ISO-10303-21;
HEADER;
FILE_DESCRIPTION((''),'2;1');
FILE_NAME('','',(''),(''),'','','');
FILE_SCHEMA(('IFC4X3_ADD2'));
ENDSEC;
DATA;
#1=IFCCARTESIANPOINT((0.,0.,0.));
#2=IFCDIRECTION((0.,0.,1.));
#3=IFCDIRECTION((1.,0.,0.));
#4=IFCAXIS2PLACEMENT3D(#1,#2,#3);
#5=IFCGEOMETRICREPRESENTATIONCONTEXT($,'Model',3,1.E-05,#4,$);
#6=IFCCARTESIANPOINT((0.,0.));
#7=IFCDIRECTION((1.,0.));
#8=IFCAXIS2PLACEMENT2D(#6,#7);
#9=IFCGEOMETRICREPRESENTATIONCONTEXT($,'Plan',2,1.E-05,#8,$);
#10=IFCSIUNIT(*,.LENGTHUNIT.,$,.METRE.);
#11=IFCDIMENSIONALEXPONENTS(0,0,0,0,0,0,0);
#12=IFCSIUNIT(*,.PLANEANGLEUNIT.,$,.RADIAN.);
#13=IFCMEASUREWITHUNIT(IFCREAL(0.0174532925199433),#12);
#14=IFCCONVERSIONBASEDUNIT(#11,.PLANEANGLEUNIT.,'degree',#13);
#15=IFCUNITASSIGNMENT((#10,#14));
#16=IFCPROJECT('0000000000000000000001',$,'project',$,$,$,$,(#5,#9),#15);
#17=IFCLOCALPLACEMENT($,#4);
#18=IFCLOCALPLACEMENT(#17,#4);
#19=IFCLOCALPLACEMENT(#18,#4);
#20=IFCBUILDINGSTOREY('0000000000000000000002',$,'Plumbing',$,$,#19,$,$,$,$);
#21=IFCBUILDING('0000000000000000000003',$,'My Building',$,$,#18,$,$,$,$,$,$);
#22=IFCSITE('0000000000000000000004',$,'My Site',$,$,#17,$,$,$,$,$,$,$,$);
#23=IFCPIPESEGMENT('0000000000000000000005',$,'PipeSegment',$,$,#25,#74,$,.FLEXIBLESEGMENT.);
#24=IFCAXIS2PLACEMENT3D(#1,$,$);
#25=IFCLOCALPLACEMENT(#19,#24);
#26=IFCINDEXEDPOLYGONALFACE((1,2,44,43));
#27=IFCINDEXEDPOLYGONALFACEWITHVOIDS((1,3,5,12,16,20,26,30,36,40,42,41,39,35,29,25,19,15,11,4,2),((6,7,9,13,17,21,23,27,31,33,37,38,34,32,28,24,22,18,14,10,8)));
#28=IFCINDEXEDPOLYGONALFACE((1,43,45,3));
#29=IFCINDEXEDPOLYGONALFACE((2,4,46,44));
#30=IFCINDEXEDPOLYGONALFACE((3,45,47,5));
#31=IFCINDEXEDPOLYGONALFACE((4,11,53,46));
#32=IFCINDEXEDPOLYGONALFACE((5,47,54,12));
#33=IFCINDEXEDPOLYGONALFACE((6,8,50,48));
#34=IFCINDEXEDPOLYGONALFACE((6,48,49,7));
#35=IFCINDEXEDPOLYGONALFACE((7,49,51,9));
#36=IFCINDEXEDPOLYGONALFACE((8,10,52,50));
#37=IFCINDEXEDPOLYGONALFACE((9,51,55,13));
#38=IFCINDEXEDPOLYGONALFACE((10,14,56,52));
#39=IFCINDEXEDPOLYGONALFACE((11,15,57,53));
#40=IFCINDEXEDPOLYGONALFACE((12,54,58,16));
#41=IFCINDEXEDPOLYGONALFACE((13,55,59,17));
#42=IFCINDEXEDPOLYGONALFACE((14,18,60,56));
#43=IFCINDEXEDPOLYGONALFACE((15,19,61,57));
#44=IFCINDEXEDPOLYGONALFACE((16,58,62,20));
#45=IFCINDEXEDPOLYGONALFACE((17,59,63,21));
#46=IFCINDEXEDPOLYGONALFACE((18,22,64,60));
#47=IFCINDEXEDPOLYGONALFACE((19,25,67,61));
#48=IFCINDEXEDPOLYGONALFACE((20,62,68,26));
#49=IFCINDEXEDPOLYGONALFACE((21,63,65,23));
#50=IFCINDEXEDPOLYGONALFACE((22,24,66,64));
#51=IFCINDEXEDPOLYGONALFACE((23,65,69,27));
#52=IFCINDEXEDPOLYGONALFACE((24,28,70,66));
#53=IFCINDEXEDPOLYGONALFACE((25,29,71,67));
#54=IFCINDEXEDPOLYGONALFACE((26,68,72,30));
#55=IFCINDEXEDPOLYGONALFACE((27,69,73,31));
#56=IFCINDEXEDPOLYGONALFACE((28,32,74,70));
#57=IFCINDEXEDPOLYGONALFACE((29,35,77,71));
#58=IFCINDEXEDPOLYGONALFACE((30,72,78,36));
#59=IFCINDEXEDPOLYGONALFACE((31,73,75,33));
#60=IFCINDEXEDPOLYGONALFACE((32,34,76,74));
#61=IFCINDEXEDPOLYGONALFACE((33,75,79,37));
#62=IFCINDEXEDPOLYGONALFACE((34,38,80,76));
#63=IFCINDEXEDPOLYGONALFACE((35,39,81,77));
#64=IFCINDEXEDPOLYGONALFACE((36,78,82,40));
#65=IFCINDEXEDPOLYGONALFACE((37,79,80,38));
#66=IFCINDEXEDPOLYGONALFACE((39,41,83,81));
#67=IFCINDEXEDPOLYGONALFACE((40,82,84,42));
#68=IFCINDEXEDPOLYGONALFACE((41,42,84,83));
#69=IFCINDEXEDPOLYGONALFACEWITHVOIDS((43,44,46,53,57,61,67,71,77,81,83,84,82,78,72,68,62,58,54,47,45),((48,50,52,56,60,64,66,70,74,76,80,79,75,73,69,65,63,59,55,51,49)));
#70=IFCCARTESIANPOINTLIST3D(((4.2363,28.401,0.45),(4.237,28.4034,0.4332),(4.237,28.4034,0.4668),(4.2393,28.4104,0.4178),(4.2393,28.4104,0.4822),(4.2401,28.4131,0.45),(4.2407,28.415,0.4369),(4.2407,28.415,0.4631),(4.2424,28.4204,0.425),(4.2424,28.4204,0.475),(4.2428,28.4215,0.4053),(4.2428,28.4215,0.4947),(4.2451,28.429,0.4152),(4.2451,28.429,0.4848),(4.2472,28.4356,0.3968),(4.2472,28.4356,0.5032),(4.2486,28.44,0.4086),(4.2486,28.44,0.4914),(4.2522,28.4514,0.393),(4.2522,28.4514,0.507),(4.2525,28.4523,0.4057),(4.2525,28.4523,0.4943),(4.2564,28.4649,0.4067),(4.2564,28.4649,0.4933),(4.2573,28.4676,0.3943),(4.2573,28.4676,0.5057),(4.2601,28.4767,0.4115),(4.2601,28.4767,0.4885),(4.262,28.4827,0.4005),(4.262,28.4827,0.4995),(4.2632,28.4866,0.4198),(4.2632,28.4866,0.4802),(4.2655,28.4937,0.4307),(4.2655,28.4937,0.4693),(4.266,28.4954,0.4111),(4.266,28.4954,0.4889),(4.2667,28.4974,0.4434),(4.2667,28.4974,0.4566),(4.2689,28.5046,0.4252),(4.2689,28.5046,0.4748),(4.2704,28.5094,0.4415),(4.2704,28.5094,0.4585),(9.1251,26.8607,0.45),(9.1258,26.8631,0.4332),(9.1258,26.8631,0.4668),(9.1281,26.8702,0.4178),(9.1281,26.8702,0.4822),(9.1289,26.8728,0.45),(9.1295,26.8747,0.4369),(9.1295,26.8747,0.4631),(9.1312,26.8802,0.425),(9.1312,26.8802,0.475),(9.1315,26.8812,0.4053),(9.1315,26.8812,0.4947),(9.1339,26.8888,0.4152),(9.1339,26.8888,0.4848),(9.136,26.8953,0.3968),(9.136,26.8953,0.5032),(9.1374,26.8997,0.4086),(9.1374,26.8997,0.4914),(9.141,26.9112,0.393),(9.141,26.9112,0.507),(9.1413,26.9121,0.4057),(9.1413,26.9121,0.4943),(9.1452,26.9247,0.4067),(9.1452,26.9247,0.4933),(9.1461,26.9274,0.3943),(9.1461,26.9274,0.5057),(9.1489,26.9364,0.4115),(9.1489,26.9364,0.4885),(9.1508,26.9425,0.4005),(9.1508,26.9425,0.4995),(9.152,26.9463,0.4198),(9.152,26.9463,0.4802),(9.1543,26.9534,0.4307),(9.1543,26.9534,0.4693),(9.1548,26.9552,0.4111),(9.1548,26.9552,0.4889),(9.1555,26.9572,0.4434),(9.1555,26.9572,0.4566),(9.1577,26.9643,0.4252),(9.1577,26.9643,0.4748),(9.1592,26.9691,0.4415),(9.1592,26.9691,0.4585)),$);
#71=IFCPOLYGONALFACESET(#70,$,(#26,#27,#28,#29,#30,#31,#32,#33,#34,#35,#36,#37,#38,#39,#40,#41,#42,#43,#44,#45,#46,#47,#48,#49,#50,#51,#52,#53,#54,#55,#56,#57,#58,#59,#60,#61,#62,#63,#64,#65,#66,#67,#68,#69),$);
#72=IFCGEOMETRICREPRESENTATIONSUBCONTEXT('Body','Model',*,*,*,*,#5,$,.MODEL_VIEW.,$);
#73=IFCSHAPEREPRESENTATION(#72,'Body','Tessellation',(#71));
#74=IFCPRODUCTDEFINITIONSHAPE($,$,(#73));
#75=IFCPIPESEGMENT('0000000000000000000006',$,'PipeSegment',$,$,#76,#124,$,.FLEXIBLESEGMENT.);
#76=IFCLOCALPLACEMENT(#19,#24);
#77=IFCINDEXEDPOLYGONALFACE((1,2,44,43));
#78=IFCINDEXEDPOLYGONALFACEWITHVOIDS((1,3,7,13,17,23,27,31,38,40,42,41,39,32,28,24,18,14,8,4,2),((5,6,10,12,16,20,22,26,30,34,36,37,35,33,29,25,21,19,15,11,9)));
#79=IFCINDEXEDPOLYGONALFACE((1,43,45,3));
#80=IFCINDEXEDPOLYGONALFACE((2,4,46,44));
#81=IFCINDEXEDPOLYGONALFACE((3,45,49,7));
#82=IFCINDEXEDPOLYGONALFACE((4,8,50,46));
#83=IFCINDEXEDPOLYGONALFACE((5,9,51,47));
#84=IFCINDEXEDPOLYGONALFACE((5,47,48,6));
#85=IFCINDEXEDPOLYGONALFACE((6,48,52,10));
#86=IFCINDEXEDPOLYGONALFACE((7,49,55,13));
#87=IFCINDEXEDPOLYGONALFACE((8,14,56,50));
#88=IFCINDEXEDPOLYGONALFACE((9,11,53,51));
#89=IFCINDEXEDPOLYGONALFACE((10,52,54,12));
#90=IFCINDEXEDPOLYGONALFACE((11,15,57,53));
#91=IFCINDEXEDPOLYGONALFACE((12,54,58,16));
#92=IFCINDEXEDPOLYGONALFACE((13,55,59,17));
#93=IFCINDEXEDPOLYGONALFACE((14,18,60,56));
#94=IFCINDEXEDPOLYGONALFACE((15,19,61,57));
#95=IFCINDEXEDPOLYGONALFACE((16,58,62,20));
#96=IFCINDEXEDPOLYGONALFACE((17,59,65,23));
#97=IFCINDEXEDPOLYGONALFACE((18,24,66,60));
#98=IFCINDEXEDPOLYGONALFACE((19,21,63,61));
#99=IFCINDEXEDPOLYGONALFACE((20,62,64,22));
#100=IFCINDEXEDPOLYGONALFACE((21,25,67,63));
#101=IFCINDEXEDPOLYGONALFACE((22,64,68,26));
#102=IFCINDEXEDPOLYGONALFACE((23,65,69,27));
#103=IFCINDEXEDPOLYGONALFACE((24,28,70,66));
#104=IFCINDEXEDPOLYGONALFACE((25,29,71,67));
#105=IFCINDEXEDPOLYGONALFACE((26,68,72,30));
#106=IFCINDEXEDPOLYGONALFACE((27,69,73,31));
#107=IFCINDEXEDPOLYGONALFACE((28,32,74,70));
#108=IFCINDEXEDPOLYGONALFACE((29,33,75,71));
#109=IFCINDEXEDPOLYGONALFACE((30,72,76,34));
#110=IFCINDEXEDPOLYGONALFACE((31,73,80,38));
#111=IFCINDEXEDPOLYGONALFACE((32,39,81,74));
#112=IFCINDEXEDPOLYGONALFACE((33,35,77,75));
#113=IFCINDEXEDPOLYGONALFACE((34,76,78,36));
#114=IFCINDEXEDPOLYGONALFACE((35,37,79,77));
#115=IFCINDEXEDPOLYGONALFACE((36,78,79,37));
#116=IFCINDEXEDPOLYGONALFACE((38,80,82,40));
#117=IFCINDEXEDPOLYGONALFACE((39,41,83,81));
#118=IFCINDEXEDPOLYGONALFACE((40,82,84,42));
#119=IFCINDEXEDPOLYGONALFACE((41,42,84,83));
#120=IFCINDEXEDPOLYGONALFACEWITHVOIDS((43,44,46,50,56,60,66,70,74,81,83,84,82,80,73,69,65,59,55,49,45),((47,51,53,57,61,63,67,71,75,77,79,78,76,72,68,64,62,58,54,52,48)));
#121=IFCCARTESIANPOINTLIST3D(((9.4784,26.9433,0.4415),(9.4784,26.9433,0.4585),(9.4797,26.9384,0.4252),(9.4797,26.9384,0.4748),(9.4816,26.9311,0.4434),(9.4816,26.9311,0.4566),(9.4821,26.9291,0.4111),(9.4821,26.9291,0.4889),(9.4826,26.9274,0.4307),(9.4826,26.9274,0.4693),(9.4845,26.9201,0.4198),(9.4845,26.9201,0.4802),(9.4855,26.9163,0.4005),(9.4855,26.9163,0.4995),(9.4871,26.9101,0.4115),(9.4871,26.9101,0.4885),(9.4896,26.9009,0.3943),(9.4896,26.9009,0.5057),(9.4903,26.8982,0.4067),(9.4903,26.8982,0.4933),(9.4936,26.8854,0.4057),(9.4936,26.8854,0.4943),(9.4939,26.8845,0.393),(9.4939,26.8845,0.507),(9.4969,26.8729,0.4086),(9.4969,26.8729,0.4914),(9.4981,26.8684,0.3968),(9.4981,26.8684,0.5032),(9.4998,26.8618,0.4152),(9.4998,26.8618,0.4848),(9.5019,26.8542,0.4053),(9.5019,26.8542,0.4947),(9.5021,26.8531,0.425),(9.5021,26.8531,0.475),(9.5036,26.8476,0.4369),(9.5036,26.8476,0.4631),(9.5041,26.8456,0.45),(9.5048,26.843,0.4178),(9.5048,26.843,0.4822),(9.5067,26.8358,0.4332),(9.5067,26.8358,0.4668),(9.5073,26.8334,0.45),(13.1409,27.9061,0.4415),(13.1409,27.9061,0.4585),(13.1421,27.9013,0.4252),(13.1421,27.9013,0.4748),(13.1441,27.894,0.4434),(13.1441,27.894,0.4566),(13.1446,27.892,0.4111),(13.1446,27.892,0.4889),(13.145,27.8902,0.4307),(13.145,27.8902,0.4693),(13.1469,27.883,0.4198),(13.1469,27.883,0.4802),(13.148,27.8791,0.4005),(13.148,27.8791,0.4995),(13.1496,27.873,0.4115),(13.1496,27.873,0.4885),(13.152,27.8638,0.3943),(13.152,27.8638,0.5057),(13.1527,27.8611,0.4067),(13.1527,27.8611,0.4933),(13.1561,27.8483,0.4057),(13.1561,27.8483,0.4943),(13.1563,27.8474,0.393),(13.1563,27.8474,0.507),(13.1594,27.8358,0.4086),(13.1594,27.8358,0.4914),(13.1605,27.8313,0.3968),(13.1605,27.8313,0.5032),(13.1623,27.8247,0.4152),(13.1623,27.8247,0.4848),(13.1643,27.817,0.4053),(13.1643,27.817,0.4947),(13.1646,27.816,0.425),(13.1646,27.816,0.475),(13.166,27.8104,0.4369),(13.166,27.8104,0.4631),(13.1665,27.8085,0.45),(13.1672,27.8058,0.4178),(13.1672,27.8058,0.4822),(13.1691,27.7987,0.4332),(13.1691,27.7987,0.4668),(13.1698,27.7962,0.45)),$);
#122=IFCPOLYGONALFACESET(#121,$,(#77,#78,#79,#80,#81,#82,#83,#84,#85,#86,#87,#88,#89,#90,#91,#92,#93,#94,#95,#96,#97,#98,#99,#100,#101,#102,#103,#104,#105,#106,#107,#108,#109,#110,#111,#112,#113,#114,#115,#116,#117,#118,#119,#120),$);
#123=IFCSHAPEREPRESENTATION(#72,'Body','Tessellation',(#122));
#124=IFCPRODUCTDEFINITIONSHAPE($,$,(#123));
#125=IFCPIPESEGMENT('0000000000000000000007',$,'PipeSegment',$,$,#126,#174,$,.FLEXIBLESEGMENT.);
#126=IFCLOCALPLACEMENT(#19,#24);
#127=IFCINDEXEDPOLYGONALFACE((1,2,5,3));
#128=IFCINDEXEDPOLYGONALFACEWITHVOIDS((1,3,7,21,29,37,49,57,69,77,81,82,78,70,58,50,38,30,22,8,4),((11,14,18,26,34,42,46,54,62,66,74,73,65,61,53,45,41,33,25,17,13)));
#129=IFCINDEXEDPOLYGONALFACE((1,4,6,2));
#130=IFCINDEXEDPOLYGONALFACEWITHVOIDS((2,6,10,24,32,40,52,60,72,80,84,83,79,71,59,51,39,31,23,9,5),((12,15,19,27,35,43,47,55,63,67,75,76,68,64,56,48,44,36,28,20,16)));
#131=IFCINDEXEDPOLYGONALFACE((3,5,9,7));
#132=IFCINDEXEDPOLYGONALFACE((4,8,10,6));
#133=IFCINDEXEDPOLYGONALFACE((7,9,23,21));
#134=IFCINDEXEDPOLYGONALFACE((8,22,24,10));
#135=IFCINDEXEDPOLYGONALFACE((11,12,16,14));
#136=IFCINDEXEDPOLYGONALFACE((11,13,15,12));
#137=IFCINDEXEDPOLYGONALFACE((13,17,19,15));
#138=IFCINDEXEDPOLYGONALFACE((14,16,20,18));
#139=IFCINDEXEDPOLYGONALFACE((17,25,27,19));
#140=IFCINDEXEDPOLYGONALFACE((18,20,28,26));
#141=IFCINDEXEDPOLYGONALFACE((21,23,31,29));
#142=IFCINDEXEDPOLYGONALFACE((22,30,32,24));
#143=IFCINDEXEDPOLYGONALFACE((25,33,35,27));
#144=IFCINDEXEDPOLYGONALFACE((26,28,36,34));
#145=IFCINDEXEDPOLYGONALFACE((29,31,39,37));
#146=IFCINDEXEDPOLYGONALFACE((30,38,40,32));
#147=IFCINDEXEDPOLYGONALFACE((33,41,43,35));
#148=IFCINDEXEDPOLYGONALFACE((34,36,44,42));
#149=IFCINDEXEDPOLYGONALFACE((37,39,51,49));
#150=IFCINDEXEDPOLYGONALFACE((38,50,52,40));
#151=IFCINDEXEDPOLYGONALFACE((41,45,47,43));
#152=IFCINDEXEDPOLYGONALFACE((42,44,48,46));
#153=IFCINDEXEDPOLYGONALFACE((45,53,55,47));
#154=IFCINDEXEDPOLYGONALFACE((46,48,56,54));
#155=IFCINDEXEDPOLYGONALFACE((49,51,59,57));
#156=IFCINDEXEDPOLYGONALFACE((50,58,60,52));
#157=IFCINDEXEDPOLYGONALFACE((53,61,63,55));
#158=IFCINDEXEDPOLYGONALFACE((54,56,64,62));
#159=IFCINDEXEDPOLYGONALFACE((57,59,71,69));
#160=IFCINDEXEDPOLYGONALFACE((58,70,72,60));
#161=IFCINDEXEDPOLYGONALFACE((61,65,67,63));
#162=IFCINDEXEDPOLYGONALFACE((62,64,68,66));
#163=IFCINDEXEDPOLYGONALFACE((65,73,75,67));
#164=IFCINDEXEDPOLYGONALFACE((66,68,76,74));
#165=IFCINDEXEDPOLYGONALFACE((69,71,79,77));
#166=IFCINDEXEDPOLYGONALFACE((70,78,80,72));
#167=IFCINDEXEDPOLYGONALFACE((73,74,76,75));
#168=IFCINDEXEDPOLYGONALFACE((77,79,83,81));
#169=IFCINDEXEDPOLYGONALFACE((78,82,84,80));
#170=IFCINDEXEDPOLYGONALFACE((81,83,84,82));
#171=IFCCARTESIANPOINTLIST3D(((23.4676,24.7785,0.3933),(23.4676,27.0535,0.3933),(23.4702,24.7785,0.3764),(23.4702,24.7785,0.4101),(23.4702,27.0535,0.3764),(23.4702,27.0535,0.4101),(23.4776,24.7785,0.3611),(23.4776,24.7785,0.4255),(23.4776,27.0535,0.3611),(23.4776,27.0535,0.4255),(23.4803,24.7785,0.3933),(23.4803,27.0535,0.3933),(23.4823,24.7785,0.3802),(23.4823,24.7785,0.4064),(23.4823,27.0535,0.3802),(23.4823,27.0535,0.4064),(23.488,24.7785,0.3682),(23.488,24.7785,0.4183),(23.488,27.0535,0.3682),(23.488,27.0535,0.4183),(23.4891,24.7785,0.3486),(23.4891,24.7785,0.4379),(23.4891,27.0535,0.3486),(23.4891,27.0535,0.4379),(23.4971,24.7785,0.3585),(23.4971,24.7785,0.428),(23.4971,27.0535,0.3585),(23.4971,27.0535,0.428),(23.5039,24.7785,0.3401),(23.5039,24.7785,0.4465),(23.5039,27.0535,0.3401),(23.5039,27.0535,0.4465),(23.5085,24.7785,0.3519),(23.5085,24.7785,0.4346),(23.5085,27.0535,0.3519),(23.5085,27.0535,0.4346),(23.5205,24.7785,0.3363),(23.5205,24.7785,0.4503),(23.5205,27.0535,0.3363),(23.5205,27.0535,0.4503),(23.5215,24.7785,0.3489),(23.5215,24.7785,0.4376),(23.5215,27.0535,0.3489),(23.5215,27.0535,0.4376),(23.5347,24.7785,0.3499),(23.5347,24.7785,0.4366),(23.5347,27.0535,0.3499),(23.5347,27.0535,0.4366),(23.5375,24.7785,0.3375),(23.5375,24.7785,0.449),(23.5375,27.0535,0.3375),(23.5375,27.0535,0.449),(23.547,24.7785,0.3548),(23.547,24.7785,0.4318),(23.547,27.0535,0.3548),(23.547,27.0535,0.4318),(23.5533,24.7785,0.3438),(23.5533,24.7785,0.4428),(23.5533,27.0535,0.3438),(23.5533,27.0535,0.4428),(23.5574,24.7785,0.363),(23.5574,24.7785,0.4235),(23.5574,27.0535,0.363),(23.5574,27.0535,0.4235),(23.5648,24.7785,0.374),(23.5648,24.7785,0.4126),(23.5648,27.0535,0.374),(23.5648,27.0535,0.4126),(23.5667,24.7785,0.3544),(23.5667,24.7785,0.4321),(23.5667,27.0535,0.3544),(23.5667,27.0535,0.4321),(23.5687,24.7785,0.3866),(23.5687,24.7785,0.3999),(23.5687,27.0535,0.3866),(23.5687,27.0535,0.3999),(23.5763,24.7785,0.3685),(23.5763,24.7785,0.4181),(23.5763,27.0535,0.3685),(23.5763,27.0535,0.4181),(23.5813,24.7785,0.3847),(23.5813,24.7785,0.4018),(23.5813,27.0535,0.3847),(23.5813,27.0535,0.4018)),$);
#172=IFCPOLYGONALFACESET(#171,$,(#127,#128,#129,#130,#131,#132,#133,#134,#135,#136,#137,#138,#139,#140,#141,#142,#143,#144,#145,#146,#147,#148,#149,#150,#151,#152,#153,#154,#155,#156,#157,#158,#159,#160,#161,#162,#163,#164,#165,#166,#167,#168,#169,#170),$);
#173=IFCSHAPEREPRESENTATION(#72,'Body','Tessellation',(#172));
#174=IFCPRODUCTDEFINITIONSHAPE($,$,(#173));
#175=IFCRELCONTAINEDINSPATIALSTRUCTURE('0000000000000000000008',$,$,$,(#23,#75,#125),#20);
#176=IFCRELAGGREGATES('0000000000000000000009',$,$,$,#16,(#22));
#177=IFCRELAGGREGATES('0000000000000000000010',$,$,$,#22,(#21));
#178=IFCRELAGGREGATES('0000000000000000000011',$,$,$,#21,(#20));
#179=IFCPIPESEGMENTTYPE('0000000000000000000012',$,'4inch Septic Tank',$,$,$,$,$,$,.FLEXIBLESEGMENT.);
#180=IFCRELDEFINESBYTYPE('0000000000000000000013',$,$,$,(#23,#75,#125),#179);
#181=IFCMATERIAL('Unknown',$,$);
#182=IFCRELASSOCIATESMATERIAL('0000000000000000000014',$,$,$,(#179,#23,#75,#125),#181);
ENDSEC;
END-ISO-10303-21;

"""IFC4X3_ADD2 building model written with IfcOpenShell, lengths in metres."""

from ifc_helpers import new_model, entity, si_unit, converted_unit, frame, origin_with_axes, origin_2d_with_axis, place, context, subcontext, project, spatial, hollow_circle, extrude, material, material_profile, profile_set, profile_usage, type_object, element, save


model = new_model("IFC4X3_ADD2")

# Units and contexts
model_context = context("Model", 3, precision=1e-05, world=origin_with_axes())
plan_context = context("Plan", 2, precision=1e-05, world=origin_2d_with_axis())
body_context = subcontext(model_context, "Body", "Model", "MODEL_VIEW")
ifc_project = project(units=[si_unit("LENGTHUNIT", "METRE"), converted_unit("PLANEANGLEUNIT", "degree", entity("IfcReal", 0.0174532925199433), si_unit("PLANEANGLEUNIT", "RADIAN"), dimensions=[0, 0, 0, 0, 0, 0, 0])], contexts=[model_context, plan_context])

# Site, building, storey
site_placement = place(None, origin_with_axes())
site = spatial("IfcSite", under=ifc_project, at=site_placement, Name="My Site")
building_placement = place(site_placement, origin_with_axes())
building = spatial("IfcBuilding", under=site, at=building_placement, Name="My Building")
storey_placement = place(building_placement, origin_with_axes())
storey = spatial("IfcBuildingStorey", under=building, at=storey_placement, Name="Plumbing")

# Pipe segments
ifc_material_1 = material(Name="Unknown")
ifc_material_profile_1 = material_profile(ifc_material_1, hollow_circle(Radius=0.0571, WallThickness=0.0127))
ifc_profile_set_1 = profile_set([ifc_material_profile_1], Name="blackwater")
ifc_material_profile_2 = material_profile(ifc_material_1, hollow_circle(Radius=0.0571, WallThickness=0.0127))
ifc_profile_set_2 = profile_set([ifc_material_profile_2], Name="blackwater")
pipe_segment_type_1 = type_object("IfcPipeSegmentType", Name="4inch Septic Tank", PredefinedType="FLEXIBLESEGMENT", material=ifc_profile_set_2)
ifc_profile_usage_1 = profile_usage(ifc_profile_set_1, cardinal=5)
pipe_segment_1_placement = place(storey_placement, frame((4.2535, 28.4555, 0.45), z_axis=(0.953784, -0.300495, 0.0), x_axis=(-0.300495, -0.953784, 0.0)))
element("IfcPipeSegment", 1, at=pipe_segment_1_placement, inside=storey, type_object=pipe_segment_type_1, material=ifc_profile_usage_1, Name="PipeSegment", PredefinedType="FLEXIBLESEGMENT", context=body_context, shape_type="SweptSolid", body=[
    extrude(hollow_circle(Radius=0.0571, WallThickness=0.0127), origin_with_axes(), (0.0, 0.0, 1.0), 5.1257),
])
ifc_profile_usage_2 = profile_usage(ifc_profile_set_1, cardinal=5)
pipe_segment_2_placement = place(storey_placement, frame((9.4928, 26.8886, 0.45), z_axis=(0.967136, 0.25426, 0.0), x_axis=(0.25426, -0.967136, -0.000001)))
element("IfcPipeSegment", 2, at=pipe_segment_2_placement, inside=storey, type_object=pipe_segment_type_1, material=ifc_profile_usage_2, Name="PipeSegment", PredefinedType="FLEXIBLESEGMENT", context=body_context, shape_type="SweptSolid", body=[
    extrude(hollow_circle(Radius=0.0571, WallThickness=0.0127), origin_with_axes(), (0.0, 0.0, 1.0), 3.7869),
])
ifc_profile_usage_3 = profile_usage(ifc_profile_set_1, cardinal=5)
pipe_segment_3_placement = place(storey_placement, frame((23.5248, 24.7785, 0.3933), z_axis=(0.0, 1.0, 0.0), x_axis=(-1.0, 0.0, 0.000001)))
element("IfcPipeSegment", 3, at=pipe_segment_3_placement, inside=storey, type_object=pipe_segment_type_1, material=ifc_profile_usage_3, Name="PipeSegment", PredefinedType="FLEXIBLESEGMENT", context=body_context, shape_type="SweptSolid", body=[
    extrude(hollow_circle(Radius=0.0571, WallThickness=0.0127), origin_with_axes(), (0.0, 0.0, 1.0), 2.2749),
])

save(model, "model.ifc")
